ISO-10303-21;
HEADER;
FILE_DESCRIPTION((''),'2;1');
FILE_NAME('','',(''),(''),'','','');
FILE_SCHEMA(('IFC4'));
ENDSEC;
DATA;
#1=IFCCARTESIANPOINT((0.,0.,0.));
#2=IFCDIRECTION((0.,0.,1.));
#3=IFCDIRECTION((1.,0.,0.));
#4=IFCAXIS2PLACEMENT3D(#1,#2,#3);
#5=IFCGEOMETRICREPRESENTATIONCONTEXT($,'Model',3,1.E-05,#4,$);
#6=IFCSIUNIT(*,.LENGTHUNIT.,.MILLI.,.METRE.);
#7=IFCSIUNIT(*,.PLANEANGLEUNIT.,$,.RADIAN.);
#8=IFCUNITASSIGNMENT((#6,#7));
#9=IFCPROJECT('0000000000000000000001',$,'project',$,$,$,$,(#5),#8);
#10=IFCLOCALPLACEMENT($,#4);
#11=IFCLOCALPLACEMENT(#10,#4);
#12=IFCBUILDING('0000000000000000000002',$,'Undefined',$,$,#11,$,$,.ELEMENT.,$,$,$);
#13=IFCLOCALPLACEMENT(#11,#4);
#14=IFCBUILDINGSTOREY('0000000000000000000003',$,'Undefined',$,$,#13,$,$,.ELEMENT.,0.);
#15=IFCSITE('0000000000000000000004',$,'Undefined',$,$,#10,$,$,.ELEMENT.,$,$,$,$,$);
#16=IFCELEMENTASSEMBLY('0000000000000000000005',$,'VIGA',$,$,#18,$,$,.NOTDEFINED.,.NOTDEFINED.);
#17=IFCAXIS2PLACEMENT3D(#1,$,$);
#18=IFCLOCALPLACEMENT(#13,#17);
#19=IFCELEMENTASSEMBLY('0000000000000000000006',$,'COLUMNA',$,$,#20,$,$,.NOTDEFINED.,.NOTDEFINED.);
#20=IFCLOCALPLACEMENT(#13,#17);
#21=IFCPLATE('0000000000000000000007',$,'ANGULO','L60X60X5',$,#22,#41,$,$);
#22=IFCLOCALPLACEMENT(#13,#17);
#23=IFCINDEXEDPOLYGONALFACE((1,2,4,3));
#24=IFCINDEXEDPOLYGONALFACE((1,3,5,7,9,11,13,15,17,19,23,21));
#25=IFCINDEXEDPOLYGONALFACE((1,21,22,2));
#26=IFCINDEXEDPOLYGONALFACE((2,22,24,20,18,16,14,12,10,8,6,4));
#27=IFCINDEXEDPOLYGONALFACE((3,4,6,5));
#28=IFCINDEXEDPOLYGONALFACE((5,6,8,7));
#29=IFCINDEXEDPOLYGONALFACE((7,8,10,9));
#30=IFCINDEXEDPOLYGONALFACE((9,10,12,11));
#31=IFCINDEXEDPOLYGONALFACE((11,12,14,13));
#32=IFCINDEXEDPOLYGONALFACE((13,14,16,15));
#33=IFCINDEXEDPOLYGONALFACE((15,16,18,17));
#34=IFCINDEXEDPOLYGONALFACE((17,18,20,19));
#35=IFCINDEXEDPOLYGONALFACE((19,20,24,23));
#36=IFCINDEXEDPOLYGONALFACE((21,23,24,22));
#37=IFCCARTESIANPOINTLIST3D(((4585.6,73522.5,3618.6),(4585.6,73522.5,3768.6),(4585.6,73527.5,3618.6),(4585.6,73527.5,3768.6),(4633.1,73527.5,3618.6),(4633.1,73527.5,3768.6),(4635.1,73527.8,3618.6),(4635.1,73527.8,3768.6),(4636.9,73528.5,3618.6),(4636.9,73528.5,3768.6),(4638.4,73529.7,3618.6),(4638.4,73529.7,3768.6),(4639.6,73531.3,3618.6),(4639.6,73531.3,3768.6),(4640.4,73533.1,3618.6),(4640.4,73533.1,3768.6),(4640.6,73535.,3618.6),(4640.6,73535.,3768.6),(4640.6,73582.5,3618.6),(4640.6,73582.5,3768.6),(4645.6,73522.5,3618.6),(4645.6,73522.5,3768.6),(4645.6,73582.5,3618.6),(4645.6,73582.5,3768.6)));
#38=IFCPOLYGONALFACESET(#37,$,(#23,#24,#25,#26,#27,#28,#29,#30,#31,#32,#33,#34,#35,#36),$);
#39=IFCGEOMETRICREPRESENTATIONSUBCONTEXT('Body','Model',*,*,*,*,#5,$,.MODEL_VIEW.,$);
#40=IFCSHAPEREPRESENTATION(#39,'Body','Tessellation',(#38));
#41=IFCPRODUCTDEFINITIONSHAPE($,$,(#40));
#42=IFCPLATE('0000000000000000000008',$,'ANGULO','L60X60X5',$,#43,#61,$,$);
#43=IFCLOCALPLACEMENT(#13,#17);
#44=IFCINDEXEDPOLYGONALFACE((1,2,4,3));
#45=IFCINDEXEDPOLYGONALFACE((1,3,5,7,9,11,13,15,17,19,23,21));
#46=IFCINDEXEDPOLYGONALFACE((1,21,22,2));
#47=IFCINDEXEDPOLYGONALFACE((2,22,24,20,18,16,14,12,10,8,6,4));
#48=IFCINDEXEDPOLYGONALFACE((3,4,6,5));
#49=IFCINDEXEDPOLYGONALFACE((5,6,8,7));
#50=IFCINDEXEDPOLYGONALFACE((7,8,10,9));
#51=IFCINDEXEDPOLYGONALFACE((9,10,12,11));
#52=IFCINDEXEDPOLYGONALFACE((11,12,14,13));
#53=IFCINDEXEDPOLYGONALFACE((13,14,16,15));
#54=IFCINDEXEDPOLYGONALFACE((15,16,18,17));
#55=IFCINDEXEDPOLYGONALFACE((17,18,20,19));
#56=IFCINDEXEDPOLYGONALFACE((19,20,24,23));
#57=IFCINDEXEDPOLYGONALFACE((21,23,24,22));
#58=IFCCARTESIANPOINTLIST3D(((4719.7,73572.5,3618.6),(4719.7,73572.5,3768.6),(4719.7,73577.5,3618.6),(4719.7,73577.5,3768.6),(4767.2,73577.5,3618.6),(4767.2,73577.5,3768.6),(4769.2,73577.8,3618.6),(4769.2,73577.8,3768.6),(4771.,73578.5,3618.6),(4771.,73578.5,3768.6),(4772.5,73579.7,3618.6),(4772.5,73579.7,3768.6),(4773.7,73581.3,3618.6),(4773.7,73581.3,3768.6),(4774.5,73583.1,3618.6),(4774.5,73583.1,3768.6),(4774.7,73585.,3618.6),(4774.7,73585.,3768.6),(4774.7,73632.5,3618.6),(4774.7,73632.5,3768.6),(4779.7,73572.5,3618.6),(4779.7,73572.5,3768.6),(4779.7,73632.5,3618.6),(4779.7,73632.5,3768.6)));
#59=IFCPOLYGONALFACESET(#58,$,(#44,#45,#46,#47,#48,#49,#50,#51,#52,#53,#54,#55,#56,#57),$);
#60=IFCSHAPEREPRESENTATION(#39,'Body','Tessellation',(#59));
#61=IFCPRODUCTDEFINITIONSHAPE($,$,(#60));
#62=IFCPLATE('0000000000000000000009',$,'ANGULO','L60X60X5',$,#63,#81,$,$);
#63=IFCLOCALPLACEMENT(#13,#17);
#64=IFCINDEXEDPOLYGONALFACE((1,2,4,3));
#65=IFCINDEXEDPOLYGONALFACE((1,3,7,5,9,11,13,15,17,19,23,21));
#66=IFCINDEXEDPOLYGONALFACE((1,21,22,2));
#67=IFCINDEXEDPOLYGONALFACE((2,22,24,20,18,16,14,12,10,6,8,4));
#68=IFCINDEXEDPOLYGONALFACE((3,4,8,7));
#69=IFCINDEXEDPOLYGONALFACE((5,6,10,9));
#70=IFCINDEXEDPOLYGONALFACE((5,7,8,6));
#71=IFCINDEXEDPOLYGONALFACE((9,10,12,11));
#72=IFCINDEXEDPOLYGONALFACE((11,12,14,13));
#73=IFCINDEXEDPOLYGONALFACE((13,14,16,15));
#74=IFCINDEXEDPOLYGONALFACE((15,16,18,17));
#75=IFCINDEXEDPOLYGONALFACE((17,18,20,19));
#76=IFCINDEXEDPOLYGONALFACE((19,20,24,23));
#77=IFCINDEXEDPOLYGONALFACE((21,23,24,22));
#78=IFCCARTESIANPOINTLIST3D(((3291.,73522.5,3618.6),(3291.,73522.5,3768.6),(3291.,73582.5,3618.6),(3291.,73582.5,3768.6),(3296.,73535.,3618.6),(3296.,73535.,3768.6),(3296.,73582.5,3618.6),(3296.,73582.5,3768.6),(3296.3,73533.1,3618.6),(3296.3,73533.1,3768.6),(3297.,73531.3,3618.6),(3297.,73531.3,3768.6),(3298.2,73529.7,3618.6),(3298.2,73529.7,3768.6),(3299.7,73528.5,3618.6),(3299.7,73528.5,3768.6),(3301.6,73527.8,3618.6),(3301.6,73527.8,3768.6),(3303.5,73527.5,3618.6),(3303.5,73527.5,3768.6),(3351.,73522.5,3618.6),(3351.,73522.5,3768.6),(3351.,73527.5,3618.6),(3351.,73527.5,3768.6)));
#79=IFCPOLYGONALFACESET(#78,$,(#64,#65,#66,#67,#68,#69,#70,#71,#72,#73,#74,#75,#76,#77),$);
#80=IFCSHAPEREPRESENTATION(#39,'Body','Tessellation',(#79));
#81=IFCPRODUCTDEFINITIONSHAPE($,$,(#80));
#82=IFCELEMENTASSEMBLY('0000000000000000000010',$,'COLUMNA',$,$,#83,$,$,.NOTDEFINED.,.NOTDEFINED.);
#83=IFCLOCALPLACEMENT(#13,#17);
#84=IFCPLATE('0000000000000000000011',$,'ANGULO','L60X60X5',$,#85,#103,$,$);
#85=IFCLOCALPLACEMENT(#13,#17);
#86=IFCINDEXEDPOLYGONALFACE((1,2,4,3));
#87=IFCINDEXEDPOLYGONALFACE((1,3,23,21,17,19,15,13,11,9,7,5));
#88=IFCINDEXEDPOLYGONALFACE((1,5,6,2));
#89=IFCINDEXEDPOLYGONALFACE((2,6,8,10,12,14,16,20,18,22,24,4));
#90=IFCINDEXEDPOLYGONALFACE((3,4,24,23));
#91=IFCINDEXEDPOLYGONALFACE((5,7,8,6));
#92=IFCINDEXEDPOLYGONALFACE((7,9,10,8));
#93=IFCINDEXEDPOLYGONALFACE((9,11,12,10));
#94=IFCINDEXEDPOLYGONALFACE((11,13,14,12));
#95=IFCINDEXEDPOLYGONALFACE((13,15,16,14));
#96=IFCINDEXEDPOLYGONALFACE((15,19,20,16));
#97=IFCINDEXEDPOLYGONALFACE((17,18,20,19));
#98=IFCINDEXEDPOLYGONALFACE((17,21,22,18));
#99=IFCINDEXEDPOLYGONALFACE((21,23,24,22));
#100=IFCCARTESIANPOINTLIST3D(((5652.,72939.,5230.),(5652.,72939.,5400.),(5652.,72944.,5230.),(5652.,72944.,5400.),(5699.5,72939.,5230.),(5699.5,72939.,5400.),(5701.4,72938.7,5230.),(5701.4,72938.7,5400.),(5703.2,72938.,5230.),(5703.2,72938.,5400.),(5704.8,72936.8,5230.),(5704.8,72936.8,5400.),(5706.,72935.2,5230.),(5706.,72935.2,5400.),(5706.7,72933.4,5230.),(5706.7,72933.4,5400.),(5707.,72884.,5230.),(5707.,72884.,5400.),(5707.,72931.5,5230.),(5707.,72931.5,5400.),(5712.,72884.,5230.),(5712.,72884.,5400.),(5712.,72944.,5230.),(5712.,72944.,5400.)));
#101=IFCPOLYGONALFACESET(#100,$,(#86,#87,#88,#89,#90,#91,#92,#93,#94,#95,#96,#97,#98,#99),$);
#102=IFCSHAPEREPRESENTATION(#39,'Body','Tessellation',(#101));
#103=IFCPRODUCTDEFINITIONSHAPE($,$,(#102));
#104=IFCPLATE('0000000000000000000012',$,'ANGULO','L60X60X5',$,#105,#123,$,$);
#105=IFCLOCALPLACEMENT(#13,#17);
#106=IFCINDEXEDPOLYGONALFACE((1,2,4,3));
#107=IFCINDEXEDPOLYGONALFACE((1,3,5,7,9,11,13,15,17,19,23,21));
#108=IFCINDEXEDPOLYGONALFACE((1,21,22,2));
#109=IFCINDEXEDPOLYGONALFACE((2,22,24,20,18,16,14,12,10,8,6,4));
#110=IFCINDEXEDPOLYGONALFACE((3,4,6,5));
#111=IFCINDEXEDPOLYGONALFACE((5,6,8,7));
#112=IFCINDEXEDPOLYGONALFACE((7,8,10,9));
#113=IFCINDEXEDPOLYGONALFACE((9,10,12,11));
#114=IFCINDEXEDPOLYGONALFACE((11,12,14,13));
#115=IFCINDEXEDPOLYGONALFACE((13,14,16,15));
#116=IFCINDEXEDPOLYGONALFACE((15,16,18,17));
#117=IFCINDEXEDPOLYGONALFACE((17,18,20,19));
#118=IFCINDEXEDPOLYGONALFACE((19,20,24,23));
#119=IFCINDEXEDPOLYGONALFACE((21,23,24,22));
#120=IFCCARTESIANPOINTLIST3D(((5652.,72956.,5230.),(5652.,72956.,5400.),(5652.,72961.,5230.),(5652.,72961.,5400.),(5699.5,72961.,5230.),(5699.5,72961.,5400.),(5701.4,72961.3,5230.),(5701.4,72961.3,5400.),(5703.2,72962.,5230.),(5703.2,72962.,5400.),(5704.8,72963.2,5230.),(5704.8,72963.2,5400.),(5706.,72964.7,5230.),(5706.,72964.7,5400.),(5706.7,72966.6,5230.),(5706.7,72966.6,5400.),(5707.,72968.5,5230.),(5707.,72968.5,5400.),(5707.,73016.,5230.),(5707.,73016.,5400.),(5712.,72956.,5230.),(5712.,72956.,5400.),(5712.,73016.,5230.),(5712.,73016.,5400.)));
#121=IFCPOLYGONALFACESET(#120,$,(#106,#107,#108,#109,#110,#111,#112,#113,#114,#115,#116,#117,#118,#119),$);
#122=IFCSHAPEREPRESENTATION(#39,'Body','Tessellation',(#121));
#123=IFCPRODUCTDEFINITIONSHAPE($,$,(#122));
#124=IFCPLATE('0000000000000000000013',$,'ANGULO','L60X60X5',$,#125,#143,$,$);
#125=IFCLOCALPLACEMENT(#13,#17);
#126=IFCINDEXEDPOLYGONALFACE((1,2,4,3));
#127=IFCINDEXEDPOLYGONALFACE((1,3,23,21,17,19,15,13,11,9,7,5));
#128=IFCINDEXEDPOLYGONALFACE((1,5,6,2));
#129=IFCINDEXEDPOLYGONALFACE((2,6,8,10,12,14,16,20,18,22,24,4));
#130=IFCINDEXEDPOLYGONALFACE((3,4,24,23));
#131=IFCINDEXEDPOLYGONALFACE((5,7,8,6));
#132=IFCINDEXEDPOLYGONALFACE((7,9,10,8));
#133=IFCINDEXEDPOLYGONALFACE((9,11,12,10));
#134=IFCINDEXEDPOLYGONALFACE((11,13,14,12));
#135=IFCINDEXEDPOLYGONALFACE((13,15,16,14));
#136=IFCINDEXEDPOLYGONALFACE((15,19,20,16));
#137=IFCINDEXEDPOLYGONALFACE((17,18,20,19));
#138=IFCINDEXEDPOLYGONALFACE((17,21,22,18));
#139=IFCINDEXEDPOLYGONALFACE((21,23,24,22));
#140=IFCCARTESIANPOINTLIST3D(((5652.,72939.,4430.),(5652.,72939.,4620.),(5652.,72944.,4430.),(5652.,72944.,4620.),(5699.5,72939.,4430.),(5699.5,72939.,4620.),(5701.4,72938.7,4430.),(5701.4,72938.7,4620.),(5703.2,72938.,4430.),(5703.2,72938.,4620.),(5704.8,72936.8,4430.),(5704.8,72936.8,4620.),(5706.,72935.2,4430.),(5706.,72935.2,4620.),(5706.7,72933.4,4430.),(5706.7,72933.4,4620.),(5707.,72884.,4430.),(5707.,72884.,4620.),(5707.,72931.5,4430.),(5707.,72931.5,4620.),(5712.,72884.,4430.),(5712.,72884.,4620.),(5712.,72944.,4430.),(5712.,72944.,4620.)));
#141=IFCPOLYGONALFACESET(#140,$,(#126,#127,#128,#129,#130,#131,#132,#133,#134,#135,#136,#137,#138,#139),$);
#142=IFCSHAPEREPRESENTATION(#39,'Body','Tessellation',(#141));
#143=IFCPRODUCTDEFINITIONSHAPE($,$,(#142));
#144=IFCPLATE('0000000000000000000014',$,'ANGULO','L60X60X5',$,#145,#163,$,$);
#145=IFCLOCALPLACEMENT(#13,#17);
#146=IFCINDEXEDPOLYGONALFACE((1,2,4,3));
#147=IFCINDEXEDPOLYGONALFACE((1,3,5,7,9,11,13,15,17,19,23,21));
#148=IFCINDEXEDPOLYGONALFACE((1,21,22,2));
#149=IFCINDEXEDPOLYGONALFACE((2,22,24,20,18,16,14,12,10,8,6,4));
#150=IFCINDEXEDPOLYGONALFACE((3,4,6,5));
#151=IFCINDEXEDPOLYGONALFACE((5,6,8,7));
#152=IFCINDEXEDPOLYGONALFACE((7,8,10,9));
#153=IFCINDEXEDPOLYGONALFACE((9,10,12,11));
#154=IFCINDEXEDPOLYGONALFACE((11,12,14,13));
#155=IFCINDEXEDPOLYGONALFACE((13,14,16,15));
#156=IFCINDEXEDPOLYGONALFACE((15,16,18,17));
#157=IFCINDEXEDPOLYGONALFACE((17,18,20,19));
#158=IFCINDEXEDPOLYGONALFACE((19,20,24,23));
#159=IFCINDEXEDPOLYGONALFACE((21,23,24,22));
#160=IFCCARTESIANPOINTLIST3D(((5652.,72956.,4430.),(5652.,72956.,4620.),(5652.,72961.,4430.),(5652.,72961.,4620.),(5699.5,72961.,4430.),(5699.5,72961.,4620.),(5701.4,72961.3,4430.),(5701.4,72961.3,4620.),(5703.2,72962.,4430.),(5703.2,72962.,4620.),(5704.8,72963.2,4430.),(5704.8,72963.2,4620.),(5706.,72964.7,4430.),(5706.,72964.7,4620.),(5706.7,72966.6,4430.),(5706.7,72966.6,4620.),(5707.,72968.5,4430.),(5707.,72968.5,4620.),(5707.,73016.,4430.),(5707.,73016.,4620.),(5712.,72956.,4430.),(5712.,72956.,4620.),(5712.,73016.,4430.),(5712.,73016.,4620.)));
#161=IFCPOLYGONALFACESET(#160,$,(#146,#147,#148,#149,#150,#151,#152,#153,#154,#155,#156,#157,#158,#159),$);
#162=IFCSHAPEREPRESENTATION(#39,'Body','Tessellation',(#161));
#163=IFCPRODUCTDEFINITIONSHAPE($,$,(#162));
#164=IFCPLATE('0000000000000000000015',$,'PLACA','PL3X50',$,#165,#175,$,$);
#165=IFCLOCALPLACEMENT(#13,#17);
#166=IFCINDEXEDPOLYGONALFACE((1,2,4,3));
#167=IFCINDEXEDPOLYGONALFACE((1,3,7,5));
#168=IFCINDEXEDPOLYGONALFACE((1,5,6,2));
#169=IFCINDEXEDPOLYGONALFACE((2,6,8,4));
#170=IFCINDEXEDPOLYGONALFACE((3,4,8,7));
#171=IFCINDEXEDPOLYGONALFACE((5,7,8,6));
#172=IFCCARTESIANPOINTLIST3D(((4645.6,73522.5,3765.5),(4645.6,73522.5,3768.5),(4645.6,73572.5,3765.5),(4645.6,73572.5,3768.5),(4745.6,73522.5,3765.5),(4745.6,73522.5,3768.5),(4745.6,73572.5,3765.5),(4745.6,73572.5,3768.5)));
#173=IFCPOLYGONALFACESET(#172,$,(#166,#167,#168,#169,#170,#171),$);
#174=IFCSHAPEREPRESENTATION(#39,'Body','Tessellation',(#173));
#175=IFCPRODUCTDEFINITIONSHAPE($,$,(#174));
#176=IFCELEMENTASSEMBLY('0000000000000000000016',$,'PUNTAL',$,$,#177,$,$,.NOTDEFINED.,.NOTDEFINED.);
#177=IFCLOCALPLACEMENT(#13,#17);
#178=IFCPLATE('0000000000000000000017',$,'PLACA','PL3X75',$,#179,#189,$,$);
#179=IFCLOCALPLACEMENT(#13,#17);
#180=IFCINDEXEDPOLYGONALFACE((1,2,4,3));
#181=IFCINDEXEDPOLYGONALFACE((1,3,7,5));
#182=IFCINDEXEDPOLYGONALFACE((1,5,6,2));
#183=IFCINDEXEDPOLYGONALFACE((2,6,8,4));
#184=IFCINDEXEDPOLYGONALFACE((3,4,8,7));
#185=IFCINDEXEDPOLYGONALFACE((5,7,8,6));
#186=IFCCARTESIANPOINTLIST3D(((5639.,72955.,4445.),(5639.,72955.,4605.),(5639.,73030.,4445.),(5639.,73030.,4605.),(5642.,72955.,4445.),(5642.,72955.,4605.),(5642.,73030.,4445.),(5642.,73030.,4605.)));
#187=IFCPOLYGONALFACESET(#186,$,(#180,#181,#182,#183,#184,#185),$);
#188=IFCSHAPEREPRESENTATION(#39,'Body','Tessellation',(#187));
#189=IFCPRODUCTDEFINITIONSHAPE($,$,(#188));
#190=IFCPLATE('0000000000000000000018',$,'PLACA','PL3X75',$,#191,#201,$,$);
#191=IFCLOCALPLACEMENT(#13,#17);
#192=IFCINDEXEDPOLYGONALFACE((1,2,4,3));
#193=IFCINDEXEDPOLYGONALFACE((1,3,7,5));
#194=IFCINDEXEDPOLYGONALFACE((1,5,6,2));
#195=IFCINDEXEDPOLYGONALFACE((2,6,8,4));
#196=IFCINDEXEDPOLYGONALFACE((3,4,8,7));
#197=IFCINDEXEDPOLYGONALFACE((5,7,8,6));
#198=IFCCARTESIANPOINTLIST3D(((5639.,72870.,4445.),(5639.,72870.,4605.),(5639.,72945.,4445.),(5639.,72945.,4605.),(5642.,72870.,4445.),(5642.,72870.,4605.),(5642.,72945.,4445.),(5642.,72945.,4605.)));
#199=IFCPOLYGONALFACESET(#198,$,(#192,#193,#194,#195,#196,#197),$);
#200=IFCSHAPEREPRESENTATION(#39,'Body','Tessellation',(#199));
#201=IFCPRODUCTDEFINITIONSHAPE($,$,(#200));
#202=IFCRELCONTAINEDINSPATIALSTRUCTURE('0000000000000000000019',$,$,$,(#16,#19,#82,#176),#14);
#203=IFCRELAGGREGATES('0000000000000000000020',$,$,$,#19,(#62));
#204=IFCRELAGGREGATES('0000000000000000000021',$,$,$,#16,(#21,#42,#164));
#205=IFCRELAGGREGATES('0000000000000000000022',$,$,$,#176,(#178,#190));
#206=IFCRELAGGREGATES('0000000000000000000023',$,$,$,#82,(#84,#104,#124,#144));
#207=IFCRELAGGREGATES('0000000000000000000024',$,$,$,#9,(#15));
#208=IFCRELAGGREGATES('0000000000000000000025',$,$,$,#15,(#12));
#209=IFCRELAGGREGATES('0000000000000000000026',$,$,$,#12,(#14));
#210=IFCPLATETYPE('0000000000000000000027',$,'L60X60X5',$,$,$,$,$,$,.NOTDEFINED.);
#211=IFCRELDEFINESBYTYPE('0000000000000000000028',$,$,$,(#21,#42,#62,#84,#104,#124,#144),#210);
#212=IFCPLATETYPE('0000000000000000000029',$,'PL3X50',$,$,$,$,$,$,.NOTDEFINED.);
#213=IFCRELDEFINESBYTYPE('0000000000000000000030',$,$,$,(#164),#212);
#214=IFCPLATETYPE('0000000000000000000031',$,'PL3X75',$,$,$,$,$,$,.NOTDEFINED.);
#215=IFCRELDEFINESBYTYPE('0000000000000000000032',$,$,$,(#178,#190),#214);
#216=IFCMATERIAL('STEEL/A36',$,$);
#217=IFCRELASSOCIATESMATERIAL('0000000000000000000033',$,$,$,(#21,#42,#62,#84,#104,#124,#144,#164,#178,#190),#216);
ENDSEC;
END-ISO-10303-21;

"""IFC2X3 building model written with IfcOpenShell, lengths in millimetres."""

from ifc_helpers import new_model, si_unit, frame, origin_with_axes, origin_2d_with_axis, place, context, subcontext, project, spatial, polyline, l_section, outline, extrude, material, type_object, element, aggregate, save


model = new_model("IFC2X3")

# Units and contexts
model_context = context("Model", 3, precision=1e-05, world=origin_with_axes())
body_context = subcontext(model_context, "Body", "Model", "MODEL_VIEW")
ifc_project = project(units=[si_unit("LENGTHUNIT", "METRE", prefix="MILLI"), si_unit("PLANEANGLEUNIT", "RADIAN")], contexts=[model_context])

# Site, building, storey
site_placement = place(None, origin_with_axes())
site = spatial("IfcSite", under=ifc_project, at=site_placement, Name="Undefined", CompositionType="ELEMENT")
building_placement = place(site_placement, origin_with_axes())
building = spatial("IfcBuilding", under=site, at=building_placement, Name="Undefined", CompositionType="ELEMENT")
storey_placement = place(building_placement, origin_with_axes())
storey = spatial("IfcBuildingStorey", under=building, at=storey_placement, Name="Undefined", CompositionType="ELEMENT", Elevation=0.0)

# Element assemblies
assembly_1_placement = place(storey_placement, origin_with_axes())
assembly_1 = element("IfcElementAssembly", 1, at=assembly_1_placement, inside=storey, Name="VIGA", AssemblyPlace="NOTDEFINED", PredefinedType="NOTDEFINED")
ifc_material_1 = material(Name="STEEL/A36")
assembly_2_placement = place(storey_placement, origin_with_axes())
assembly_2 = element("IfcElementAssembly", 2, at=assembly_2_placement, inside=storey, Name="COLUMNA", AssemblyPlace="NOTDEFINED", PredefinedType="NOTDEFINED")

# Plates
plate_type_1 = type_object("IfcPlateType", Name="L60X60X5", PredefinedType="NOTDEFINED")
plate_1_placement = place(assembly_1_placement, frame((4615.6, 73552.5, 3618.6), z_axis=(0.0, 1.0, 0.0), x_axis=(0.0, 0.0, 1.0)))
plate_1 = element("IfcPlate", 3, at=plate_1_placement, type_object=plate_type_1, material=ifc_material_1, Name="ANGULO", Description="L60X60X5", context=body_context, shape_type="SweptSolid", body=[
    extrude(l_section(Depth=60.0, Width=60.0, Thickness=5.0, FilletRadius=7.5, at=origin_2d_with_axis()), frame((150.0, 0.0, 0.0), z_axis=(-1.0, 0.0, 0.0), x_axis=(0.0, -1.0, 0.0)), (0.0, 0.0, 1.0), 150.0),
])
plate_2_placement = place(assembly_1_placement, frame((4749.7, 73602.5, 3768.6), z_axis=(-1.0, 0.0, 0.0), x_axis=(0.0, 0.0, -1.0)))
plate_2 = element("IfcPlate", 4, at=plate_2_placement, type_object=plate_type_1, material=ifc_material_1, Name="ANGULO", Description="L60X60X5", context=body_context, shape_type="SweptSolid", body=[
    extrude(l_section(Depth=60.0, Width=60.0, Thickness=5.0, FilletRadius=7.5, at=origin_2d_with_axis()), frame((150.0, 0.0, 0.0), z_axis=(-1.0, 0.0, 0.0), x_axis=(0.0, -1.0, 0.0)), (0.0, 0.0, 1.0), 150.0),
])
plate_3_placement = place(assembly_2_placement, frame((3321.0, 73552.5, 3768.6), z_axis=(0.0, 1.0, 0.0), x_axis=(0.0, 0.0, -1.0)))
plate_3 = element("IfcPlate", 5, at=plate_3_placement, type_object=plate_type_1, material=ifc_material_1, Name="ANGULO", Description="L60X60X5", context=body_context, shape_type="SweptSolid", body=[
    extrude(l_section(Depth=60.0, Width=60.0, Thickness=5.0, FilletRadius=7.5, at=origin_2d_with_axis()), frame((150.0, 0.0, 0.0), z_axis=(-1.0, 0.0, 0.0), x_axis=(0.0, -1.0, 0.0)), (0.0, 0.0, 1.0), 150.0),
])
aggregate(assembly_2, [plate_3])

# Element assembly, plates
assembly_3_placement = place(storey_placement, origin_with_axes())
assembly_3 = element("IfcElementAssembly", 6, at=assembly_3_placement, inside=storey, Name="COLUMNA", AssemblyPlace="NOTDEFINED", PredefinedType="NOTDEFINED")
plate_4_placement = place(assembly_3_placement, frame((5682.0, 72914.0, 5400.0), z_axis=(0.0, -1.0, 0.0), x_axis=(0.0, 0.0, -1.0)))
plate_4 = element("IfcPlate", 7, at=plate_4_placement, type_object=plate_type_1, material=ifc_material_1, Name="ANGULO", Description="L60X60X5", context=body_context, shape_type="SweptSolid", body=[
    extrude(l_section(Depth=60.0, Width=60.0, Thickness=5.0, FilletRadius=7.5, at=origin_2d_with_axis()), frame((170.0, 0.0, 0.0), z_axis=(-1.0, 0.0, 0.0), x_axis=(0.0, -1.0, 0.0)), (0.0, 0.0, 1.0), 170.0),
])
plate_5_placement = place(assembly_3_placement, frame((5682.0, 72986.0, 5230.0), z_axis=(0.0, 1.0, 0.0), x_axis=(0.0, 0.0, 1.0)))
plate_5 = element("IfcPlate", 8, at=plate_5_placement, type_object=plate_type_1, material=ifc_material_1, Name="ANGULO", Description="L60X60X5", context=body_context, shape_type="SweptSolid", body=[
    extrude(l_section(Depth=60.0, Width=60.0, Thickness=5.0, FilletRadius=7.5, at=origin_2d_with_axis()), frame((170.0, 0.0, 0.0), z_axis=(-1.0, 0.0, 0.0), x_axis=(0.0, -1.0, 0.0)), (0.0, 0.0, 1.0), 170.0),
])
plate_6_placement = place(assembly_3_placement, frame((5682.0, 72914.0, 4620.0), z_axis=(0.0, -1.0, 0.0), x_axis=(0.0, 0.0, -1.0)))
plate_6 = element("IfcPlate", 9, at=plate_6_placement, type_object=plate_type_1, material=ifc_material_1, Name="ANGULO", Description="L60X60X5", context=body_context, shape_type="SweptSolid", body=[
    extrude(l_section(Depth=60.0, Width=60.0, Thickness=5.0, FilletRadius=7.5, at=origin_2d_with_axis()), frame((190.0, 0.0, 0.0), z_axis=(-1.0, 0.0, 0.0), x_axis=(0.0, -1.0, 0.0)), (0.0, 0.0, 1.0), 190.0),
])
plate_7_placement = place(assembly_3_placement, frame((5682.0, 72986.0, 4430.0), z_axis=(0.0, 1.0, 0.0), x_axis=(0.0, 0.0, 1.0)))
plate_7 = element("IfcPlate", 10, at=plate_7_placement, type_object=plate_type_1, material=ifc_material_1, Name="ANGULO", Description="L60X60X5", context=body_context, shape_type="SweptSolid", body=[
    extrude(l_section(Depth=60.0, Width=60.0, Thickness=5.0, FilletRadius=7.5, at=origin_2d_with_axis()), frame((190.0, 0.0, 0.0), z_axis=(-1.0, 0.0, 0.0), x_axis=(0.0, -1.0, 0.0)), (0.0, 0.0, 1.0), 190.0),
])

# Plate
plate_type_2 = type_object("IfcPlateType", Name="PL3X50", PredefinedType="NOTDEFINED")
plate_8_placement = place(assembly_1_placement, frame((4645.6, 73522.5, 3767.0), z_axis=(0.0, 0.0, -1.0), x_axis=(0.0, 1.0, 0.0)))
plate_8 = element("IfcPlate", 11, at=plate_8_placement, type_object=plate_type_2, material=ifc_material_1, Name="PLACA", Description="PL3X50", context=body_context, shape_type="SweptSolid", body=[
    extrude(outline(polyline([(0.0, 0.0), (50.0, 0.0), (50.0, 100.0), (0.0, 100.0), (0.0, 0.0)])), frame((0.0, 0.0, -1.5), z_axis=(0.0, 0.0, 1.0), x_axis=(1.0, 0.0, 0.0)), (0.0, 0.0, 1.0), 3.0),
])
aggregate(assembly_1, [plate_1, plate_2, plate_8])

# Element assembly, plates
assembly_4_placement = place(storey_placement, origin_with_axes())
assembly_4 = element("IfcElementAssembly", 12, at=assembly_4_placement, inside=storey, Name="PUNTAL", AssemblyPlace="NOTDEFINED", PredefinedType="NOTDEFINED")
plate_type_3 = type_object("IfcPlateType", Name="PL3X75", PredefinedType="NOTDEFINED")
plate_9_placement = place(assembly_4_placement, frame((5640.5, 73030.0, 4605.0), z_axis=(1.0, 0.0, 0.0), x_axis=(0.0, -1.0, 0.0)))
plate_9 = element("IfcPlate", 13, at=plate_9_placement, type_object=plate_type_3, material=ifc_material_1, Name="PLACA", Description="PL3X75", context=body_context, shape_type="SweptSolid", body=[
    extrude(outline(polyline([(0.0, 0.0), (75.0, 0.0), (75.0, 160.0), (0.0, 160.0), (0.0, 0.0)])), frame((0.0, 0.0, -1.5), z_axis=(0.0, 0.0, 1.0), x_axis=(1.0, 0.0, 0.0)), (0.0, 0.0, 1.0), 3.0),
])
plate_10_placement = place(assembly_4_placement, frame((5640.5, 72945.0, 4605.0), z_axis=(1.0, 0.0, 0.0), x_axis=(0.0, -1.0, 0.0)))
plate_10 = element("IfcPlate", 14, at=plate_10_placement, type_object=plate_type_3, material=ifc_material_1, Name="PLACA", Description="PL3X75", context=body_context, shape_type="SweptSolid", body=[
    extrude(outline(polyline([(0.0, 0.0), (75.0, 0.0), (75.0, 160.0), (0.0, 160.0), (0.0, 0.0)])), frame((0.0, 0.0, -1.5), z_axis=(0.0, 0.0, 1.0), x_axis=(1.0, 0.0, 0.0)), (0.0, 0.0, 1.0), 3.0),
])

aggregate(assembly_4, [plate_9, plate_10])

aggregate(assembly_3, [plate_4, plate_5, plate_6, plate_7])

save(model, "model.ifc")
